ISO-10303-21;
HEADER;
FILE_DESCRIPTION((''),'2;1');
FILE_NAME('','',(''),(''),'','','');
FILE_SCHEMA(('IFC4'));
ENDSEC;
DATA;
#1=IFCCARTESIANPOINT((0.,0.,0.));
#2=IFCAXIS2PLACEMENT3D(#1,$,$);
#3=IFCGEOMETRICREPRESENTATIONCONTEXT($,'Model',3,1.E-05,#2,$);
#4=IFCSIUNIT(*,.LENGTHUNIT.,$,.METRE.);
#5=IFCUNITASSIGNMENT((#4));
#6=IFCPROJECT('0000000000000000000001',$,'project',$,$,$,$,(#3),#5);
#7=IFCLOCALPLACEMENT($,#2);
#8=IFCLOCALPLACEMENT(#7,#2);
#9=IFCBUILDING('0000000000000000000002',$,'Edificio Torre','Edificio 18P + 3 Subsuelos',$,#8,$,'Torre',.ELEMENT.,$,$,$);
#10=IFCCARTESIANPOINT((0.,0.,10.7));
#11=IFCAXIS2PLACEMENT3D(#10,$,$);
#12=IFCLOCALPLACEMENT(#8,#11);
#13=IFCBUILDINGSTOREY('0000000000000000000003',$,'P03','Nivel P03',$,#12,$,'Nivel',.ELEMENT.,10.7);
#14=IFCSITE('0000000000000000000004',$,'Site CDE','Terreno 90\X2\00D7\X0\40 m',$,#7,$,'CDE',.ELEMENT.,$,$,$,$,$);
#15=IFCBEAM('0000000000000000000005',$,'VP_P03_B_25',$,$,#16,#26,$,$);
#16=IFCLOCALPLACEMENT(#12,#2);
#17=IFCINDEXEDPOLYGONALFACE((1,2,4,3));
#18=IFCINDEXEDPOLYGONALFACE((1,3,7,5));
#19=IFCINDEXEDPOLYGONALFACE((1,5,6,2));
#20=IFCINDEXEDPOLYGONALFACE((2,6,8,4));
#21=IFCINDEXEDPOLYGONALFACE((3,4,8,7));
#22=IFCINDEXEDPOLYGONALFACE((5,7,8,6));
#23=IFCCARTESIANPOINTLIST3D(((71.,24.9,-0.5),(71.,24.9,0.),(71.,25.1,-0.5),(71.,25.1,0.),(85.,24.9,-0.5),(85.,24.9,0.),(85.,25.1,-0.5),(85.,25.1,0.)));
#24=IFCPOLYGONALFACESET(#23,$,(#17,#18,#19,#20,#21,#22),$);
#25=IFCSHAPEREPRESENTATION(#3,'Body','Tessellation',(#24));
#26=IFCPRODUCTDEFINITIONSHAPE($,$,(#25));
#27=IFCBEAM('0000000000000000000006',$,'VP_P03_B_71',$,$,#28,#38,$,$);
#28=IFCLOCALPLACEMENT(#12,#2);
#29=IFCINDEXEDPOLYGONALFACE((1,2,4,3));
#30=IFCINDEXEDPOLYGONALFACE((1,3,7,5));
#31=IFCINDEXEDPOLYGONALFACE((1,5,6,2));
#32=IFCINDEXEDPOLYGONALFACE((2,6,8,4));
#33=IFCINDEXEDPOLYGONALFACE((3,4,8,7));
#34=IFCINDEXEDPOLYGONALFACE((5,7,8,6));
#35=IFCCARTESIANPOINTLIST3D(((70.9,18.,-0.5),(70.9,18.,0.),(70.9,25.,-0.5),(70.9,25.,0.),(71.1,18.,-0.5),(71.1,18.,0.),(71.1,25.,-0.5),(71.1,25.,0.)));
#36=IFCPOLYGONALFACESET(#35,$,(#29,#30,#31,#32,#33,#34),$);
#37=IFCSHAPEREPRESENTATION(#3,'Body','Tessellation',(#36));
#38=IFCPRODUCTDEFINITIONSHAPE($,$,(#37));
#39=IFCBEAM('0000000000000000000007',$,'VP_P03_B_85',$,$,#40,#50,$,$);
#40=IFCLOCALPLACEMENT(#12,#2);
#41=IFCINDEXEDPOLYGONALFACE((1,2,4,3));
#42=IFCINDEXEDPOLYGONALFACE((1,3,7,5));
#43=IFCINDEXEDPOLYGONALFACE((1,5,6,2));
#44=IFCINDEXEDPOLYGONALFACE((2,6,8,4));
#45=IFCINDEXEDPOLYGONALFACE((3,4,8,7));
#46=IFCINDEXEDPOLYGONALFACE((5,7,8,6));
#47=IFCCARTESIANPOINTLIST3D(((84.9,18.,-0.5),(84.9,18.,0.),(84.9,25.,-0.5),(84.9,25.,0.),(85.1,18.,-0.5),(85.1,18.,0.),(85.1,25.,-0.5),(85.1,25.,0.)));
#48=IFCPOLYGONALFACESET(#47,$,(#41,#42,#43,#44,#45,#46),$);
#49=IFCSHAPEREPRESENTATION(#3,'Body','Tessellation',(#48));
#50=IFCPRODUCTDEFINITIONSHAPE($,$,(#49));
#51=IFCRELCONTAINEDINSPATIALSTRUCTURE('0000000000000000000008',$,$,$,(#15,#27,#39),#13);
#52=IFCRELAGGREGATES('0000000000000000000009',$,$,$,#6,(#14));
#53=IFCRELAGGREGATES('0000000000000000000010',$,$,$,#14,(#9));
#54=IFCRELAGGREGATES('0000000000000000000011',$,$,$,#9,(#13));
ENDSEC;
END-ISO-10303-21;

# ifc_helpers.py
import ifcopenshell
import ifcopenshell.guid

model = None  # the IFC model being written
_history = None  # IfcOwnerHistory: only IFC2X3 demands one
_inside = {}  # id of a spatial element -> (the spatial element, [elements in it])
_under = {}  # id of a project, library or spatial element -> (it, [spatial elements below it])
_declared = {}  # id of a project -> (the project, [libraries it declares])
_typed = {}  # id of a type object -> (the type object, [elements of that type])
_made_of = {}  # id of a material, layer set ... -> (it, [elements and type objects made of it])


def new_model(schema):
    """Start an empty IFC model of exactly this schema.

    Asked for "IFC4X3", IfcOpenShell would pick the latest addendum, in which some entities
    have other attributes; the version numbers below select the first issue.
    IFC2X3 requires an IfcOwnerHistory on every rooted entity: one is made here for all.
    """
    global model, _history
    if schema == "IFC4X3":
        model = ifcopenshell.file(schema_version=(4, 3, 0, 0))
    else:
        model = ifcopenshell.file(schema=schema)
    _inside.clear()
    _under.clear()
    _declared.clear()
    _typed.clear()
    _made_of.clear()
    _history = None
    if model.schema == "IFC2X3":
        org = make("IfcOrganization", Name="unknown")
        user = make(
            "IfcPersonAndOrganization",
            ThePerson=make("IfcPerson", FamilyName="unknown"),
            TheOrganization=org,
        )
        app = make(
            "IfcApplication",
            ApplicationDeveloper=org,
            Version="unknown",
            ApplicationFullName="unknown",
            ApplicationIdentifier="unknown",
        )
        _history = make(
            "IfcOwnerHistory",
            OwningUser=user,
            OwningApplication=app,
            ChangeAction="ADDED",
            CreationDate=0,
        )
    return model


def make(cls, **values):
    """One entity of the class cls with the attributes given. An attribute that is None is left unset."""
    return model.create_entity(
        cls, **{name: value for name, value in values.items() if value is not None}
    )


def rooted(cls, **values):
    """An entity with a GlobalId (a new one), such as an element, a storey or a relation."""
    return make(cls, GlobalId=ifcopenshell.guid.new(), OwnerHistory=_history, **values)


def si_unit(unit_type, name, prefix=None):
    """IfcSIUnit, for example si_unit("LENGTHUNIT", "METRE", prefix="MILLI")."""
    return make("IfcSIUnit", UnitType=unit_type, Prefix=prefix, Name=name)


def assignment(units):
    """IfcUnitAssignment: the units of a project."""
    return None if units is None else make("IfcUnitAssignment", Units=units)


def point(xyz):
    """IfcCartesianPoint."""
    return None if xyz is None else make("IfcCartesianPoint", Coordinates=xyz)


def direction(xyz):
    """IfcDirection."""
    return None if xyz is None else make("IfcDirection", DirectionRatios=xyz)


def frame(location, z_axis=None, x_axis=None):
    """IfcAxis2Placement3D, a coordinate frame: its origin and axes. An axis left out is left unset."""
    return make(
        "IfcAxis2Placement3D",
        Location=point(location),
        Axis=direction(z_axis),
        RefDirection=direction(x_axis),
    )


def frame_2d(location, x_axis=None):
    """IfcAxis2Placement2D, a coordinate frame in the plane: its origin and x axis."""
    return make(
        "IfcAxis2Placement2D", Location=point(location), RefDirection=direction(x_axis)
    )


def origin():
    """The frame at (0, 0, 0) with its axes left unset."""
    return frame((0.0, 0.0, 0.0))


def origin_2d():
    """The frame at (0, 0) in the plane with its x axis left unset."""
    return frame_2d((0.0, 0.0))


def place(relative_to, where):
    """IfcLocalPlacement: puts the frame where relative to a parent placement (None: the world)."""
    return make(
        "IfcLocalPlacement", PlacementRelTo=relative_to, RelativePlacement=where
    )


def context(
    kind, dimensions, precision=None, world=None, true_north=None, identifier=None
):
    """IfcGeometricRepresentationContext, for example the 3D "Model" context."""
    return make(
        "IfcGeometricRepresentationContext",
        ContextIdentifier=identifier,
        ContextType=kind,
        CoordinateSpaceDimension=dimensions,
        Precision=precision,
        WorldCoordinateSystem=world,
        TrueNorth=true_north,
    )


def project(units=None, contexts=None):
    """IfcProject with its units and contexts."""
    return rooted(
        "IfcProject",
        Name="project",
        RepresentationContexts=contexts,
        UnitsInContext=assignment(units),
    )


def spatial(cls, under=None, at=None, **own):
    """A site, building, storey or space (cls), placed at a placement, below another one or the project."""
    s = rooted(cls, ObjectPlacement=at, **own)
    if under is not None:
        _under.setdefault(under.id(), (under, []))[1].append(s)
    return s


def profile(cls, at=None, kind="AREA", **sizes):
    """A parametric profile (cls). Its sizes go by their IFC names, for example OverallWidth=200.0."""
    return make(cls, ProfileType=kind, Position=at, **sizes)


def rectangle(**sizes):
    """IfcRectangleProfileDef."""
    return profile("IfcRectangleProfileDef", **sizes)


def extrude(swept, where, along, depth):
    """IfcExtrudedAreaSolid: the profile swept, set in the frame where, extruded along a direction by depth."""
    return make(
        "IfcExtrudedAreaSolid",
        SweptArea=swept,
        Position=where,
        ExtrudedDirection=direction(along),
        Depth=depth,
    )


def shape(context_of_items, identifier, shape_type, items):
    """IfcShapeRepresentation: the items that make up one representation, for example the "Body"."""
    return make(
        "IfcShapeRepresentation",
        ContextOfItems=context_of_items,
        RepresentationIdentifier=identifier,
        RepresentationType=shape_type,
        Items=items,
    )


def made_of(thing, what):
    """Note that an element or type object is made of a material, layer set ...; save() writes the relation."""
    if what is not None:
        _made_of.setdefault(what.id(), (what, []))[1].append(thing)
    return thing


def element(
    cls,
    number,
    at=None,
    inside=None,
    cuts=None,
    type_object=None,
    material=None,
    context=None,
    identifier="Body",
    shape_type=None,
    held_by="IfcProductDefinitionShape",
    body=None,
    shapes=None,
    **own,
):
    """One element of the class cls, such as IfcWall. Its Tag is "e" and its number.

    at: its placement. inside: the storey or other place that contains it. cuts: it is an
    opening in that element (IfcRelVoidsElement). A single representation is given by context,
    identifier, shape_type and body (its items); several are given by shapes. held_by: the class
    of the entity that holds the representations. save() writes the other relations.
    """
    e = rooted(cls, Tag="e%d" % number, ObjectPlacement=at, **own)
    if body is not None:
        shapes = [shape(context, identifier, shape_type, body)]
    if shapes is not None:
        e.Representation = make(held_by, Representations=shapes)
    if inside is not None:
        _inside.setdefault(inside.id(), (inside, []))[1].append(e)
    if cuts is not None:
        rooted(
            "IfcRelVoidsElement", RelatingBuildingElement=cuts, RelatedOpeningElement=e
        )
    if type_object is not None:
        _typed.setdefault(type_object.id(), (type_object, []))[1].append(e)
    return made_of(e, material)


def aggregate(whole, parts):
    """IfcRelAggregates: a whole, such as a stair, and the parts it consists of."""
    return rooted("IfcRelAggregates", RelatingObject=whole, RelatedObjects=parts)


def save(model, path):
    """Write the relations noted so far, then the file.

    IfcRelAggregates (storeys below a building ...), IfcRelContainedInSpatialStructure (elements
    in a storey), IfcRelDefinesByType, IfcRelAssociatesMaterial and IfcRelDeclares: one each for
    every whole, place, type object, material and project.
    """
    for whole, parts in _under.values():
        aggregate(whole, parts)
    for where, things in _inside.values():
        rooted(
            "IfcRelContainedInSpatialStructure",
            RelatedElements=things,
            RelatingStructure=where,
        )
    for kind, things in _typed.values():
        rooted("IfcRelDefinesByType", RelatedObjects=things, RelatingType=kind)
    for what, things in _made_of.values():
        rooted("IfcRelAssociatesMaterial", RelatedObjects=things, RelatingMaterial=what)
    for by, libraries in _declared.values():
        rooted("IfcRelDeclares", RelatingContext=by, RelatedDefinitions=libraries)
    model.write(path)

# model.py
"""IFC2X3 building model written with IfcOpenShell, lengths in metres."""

from ifc_helpers import new_model, si_unit, frame, origin, origin_2d, place, context, project, spatial, rectangle, extrude, element, save


model = new_model("IFC2X3")

# Units and contexts
model_context = context("Model", 3, precision=1e-05, world=origin())
ifc_project = project(units=[si_unit("LENGTHUNIT", "METRE")], contexts=[model_context])

# Site, building, storey
site_placement = place(None, origin())
site = spatial("IfcSite", under=ifc_project, at=site_placement, Name="Site CDE", Description="Terreno 90×40 m", LongName="CDE", CompositionType="ELEMENT")
building_placement = place(site_placement, origin())
building = spatial("IfcBuilding", under=site, at=building_placement, Name="Edificio Torre", Description="Edificio 18P + 3 Subsuelos", LongName="Torre", CompositionType="ELEMENT")
storey_placement = place(building_placement, frame((0.0, 0.0, 10.7)))
storey = spatial("IfcBuildingStorey", under=building, at=storey_placement, Name="P03", Description="Nivel P03", LongName="Nivel", CompositionType="ELEMENT", Elevation=10.7)

# Beams
for number, where, name in (
    (1, (78.0, 25.0, -0.5), "VP_P03_B_25"),
):
    element("IfcBeam", number, at=place(storey_placement, frame(where)), inside=storey, Name=name, context=model_context, shape_type="SweptSolid", body=[
        extrude(rectangle(XDim=14.0, YDim=0.2, at=origin_2d()), origin(), (0.0, 0.0, 1.0), 0.5),
    ])
for number, where, name in (
    (2, (71.0, 21.5, -0.5), "VP_P03_B_71"),
    (3, (85.0, 21.5, -0.5), "VP_P03_B_85"),
):
    element("IfcBeam", number, at=place(storey_placement, frame(where)), inside=storey, Name=name, context=model_context, shape_type="SweptSolid", body=[
        extrude(rectangle(XDim=0.2, YDim=7.0, at=origin_2d()), origin(), (0.0, 0.0, 1.0), 0.5),
    ])

save(model, "model.ifc")
